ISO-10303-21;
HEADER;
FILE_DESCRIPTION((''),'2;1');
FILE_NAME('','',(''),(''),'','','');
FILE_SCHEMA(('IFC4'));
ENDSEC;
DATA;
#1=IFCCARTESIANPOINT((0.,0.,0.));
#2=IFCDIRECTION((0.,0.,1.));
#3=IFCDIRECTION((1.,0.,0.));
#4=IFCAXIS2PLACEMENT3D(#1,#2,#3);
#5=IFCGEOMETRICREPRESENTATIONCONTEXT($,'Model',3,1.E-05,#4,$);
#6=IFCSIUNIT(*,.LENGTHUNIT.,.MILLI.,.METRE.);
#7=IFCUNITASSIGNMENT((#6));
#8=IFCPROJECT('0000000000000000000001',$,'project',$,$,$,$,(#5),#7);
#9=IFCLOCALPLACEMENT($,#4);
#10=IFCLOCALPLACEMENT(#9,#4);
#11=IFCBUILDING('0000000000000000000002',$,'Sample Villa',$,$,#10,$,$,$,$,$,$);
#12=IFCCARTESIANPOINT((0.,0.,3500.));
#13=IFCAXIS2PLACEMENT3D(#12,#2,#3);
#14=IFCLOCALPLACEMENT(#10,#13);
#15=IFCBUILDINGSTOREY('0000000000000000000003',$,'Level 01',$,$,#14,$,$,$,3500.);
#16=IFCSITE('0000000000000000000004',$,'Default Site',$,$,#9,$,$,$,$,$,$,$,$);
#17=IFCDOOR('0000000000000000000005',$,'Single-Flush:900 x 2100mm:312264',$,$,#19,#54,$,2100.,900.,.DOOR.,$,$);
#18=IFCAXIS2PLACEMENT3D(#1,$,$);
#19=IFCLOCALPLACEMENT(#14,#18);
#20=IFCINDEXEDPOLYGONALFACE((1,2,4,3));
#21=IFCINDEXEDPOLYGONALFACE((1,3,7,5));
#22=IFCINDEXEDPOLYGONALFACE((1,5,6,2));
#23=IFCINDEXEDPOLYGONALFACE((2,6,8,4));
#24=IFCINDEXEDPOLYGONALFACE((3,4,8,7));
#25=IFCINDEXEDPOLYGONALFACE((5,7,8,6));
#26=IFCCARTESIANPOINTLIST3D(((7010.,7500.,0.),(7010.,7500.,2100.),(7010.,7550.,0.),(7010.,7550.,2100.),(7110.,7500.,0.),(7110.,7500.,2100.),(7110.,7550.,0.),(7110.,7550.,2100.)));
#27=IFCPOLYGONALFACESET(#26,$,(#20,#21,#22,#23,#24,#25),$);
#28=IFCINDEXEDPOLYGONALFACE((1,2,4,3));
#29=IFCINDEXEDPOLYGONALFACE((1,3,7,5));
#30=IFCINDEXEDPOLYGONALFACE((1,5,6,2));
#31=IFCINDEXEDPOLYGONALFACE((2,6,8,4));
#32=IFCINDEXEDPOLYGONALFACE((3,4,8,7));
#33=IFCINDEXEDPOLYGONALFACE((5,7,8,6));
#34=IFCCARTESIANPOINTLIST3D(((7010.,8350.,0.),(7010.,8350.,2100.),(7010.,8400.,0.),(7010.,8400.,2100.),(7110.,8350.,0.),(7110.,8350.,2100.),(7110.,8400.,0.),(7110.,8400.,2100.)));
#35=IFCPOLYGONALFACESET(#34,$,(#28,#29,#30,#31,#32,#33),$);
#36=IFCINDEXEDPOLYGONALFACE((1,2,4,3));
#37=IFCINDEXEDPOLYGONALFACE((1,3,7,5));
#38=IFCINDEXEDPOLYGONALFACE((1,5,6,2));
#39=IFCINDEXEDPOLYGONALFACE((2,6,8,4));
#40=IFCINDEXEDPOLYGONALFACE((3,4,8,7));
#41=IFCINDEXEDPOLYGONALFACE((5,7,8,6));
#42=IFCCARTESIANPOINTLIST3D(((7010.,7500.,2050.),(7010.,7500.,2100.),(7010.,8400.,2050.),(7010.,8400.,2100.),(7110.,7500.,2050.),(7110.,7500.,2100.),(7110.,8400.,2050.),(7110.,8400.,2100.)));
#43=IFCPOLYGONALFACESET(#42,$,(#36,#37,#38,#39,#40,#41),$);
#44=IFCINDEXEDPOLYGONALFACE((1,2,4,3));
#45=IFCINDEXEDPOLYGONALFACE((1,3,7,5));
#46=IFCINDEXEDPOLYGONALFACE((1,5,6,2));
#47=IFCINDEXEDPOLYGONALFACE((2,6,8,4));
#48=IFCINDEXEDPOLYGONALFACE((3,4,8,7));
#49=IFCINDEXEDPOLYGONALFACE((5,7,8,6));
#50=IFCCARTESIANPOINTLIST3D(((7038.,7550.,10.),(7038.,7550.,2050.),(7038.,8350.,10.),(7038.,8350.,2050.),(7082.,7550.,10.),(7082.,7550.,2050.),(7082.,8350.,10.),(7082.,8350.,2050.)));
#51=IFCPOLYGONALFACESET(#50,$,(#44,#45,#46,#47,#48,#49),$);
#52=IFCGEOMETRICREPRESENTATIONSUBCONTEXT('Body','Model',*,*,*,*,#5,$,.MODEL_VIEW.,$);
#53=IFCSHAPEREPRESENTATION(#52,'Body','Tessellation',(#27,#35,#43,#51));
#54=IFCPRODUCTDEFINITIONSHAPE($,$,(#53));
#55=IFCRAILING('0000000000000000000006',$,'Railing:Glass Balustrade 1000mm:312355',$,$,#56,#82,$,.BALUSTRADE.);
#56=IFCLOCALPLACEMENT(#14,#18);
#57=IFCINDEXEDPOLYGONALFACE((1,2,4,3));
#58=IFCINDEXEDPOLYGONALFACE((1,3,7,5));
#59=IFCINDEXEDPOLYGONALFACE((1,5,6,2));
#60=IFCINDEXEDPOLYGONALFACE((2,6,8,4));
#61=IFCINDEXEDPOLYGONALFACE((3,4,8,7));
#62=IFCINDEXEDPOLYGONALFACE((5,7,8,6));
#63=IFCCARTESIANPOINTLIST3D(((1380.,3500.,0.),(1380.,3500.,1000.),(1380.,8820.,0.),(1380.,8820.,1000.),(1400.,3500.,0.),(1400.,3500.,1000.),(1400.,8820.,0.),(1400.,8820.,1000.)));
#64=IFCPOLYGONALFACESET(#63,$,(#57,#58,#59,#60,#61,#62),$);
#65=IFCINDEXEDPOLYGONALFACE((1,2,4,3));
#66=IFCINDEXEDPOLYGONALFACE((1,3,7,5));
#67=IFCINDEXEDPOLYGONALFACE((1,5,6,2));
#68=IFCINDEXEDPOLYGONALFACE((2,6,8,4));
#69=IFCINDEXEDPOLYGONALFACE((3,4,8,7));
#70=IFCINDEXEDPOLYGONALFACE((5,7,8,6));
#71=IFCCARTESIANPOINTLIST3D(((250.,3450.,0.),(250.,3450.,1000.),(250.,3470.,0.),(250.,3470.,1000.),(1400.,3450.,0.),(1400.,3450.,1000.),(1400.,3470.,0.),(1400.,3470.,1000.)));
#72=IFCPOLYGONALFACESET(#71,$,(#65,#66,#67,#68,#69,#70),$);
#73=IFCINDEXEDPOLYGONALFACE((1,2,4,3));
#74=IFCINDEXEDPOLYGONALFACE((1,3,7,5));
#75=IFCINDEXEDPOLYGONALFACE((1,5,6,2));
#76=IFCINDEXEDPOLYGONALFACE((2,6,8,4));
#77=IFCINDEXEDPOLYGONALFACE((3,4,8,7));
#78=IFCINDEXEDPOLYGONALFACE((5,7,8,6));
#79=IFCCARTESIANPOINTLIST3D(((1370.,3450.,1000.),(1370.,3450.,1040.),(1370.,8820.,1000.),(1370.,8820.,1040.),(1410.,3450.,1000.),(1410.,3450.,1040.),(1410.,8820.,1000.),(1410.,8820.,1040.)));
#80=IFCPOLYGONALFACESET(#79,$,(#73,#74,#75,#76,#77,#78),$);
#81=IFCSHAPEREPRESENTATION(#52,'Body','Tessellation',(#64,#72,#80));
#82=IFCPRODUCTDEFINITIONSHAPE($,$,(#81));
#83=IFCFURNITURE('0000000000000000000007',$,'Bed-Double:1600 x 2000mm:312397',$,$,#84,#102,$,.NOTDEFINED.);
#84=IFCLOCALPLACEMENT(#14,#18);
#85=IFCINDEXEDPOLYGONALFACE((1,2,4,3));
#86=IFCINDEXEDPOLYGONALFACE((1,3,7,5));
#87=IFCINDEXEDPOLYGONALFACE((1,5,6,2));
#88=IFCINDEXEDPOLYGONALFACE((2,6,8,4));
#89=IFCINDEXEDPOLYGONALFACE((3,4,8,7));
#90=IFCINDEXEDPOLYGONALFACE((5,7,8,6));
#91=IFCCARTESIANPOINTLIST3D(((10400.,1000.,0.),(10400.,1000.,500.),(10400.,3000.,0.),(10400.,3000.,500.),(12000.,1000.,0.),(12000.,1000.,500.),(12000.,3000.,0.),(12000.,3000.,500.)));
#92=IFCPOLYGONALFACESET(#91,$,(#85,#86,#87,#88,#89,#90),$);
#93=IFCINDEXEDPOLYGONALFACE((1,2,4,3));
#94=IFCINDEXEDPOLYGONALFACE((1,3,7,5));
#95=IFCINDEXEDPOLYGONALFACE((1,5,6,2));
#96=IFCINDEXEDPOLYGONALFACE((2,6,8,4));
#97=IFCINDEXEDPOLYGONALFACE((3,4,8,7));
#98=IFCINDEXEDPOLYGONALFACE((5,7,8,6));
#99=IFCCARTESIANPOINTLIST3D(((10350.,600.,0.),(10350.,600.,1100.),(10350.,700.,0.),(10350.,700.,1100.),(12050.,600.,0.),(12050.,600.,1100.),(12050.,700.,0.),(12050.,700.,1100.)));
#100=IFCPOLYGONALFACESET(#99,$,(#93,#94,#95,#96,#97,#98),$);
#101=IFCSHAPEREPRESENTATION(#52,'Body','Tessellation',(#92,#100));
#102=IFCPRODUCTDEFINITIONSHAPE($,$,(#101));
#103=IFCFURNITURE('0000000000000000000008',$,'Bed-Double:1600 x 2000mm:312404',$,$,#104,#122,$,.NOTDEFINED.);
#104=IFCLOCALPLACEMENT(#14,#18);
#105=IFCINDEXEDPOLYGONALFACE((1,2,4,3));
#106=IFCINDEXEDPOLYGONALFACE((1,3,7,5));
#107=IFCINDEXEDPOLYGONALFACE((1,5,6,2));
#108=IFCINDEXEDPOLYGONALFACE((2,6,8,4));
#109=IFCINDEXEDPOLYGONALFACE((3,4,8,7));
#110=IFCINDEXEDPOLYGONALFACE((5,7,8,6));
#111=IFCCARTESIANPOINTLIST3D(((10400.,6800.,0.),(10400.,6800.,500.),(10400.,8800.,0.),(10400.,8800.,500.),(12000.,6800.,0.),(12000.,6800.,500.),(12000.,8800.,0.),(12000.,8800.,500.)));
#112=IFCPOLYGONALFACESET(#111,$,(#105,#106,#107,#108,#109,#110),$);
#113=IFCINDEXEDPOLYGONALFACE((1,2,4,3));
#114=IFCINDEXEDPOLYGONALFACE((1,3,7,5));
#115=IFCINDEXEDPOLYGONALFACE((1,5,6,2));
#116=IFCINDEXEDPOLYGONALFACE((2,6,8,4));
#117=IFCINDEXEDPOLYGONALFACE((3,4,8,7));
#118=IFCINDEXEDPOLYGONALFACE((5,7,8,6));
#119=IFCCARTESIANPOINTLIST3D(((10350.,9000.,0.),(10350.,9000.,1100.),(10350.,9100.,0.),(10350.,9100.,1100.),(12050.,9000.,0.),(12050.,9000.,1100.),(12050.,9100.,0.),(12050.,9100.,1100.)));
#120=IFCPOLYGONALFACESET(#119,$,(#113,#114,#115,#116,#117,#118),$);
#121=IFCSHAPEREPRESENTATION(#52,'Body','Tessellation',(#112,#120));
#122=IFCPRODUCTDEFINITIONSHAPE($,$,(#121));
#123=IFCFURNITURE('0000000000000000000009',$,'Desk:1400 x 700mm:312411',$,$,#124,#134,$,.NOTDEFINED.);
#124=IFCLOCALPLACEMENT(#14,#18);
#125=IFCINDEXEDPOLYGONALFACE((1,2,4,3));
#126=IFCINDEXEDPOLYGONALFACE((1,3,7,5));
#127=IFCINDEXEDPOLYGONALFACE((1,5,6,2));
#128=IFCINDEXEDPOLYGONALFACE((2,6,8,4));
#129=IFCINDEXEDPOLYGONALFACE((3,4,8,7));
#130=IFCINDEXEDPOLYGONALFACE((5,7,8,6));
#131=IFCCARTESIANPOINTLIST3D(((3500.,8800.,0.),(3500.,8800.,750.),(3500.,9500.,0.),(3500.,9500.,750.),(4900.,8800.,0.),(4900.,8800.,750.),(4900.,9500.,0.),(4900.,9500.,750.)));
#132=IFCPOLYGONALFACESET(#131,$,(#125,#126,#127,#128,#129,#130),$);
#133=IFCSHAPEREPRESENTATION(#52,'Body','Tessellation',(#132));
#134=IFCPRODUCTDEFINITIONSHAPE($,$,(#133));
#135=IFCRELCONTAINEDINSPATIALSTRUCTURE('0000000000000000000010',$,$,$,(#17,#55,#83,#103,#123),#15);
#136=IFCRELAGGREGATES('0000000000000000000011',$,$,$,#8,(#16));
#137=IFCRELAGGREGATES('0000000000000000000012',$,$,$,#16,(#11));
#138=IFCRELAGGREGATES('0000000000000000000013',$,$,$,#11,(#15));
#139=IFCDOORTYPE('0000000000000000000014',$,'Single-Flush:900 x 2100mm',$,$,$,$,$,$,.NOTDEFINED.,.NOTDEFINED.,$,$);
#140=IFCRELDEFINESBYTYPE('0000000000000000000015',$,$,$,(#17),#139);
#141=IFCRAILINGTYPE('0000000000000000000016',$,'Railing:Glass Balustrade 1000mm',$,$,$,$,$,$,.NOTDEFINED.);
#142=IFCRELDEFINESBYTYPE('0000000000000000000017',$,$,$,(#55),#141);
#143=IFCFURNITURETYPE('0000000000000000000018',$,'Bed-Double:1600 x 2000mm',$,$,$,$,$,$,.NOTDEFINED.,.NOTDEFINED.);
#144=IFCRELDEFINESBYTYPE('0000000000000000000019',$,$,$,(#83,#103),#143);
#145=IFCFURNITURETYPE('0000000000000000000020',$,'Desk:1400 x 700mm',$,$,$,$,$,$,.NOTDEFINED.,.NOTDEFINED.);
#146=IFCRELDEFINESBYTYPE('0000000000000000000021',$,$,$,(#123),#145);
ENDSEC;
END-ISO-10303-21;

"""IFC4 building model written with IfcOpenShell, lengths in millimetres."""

from ifc_helpers import new_model, si_unit, frame, frame_2d, origin_with_axes, place, context, subcontext, project, spatial, rectangle, extrude, type_object, element, save


model = new_model("IFC4")

# Units and contexts
model_context = context("Model", 3, precision=1e-05, world=origin_with_axes())
body_context = subcontext(model_context, "Body", "Model", "MODEL_VIEW")
ifc_project = project(units=[si_unit("LENGTHUNIT", "METRE", prefix="MILLI")], contexts=[model_context])

# Site, building, storey
site_placement = place(None, origin_with_axes())
site = spatial("IfcSite", under=ifc_project, at=site_placement, Name="Default Site")
building_placement = place(site_placement, origin_with_axes())
building = spatial("IfcBuilding", under=site, at=building_placement, Name="Sample Villa")
storey_placement = place(building_placement, frame((0.0, 0.0, 3500.0), z_axis=(0.0, 0.0, 1.0), x_axis=(1.0, 0.0, 0.0)))
storey = spatial("IfcBuildingStorey", under=building, at=storey_placement, Name="Level 01", Elevation=3500.0)

# Door
door_type = type_object("IfcDoorType", Name="Single-Flush:900 x 2100mm", OperationType="NOTDEFINED", PredefinedType="NOTDEFINED")
door_1_placement = place(storey_placement, frame((0.0, 0.0, -3500.0), z_axis=(0.0, 0.0, 1.0), x_axis=(1.0, 0.0, 0.0)))
element("IfcDoor", 1, at=door_1_placement, inside=storey, type_object=door_type, Name="Single-Flush:900 x 2100mm:312264", OverallHeight=2100.0, OverallWidth=900.0, PredefinedType="DOOR", context=body_context, shape_type="SweptSolid", body=[
    extrude(rectangle(XDim=100.0, YDim=50.0, at=frame_2d((50.0, 25.0))), frame((7010.0, 7500.0, 3500.0)), (0.0, 0.0, 1.0), 2100.0),
    extrude(rectangle(XDim=100.0, YDim=50.0, at=frame_2d((50.0, 25.0))), frame((7010.0, 8350.0, 3500.0)), (0.0, 0.0, 1.0), 2100.0),
    extrude(rectangle(XDim=100.0, YDim=900.0, at=frame_2d((50.0, 450.0))), frame((7010.0, 7500.0, 5550.0)), (0.0, 0.0, 1.0), 50.0),
    extrude(rectangle(XDim=44.0, YDim=800.0, at=frame_2d((22.0, 400.0))), frame((7038.0, 7550.0, 3510.0)), (0.0, 0.0, 1.0), 2040.0),
])

# Railing
railing_type = type_object("IfcRailingType", Name="Railing:Glass Balustrade 1000mm", PredefinedType="NOTDEFINED")
railing_placement = place(storey_placement, frame((0.0, 0.0, -3500.0), z_axis=(0.0, 0.0, 1.0), x_axis=(1.0, 0.0, 0.0)))
element("IfcRailing", 2, at=railing_placement, inside=storey, type_object=railing_type, Name="Railing:Glass Balustrade 1000mm:312355", PredefinedType="BALUSTRADE", context=body_context, shape_type="SweptSolid", body=[
    extrude(rectangle(XDim=20.0, YDim=5320.0, at=frame_2d((10.0, 2660.0))), frame((1380.0, 3500.0, 3500.0)), (0.0, 0.0, 1.0), 1000.0),
    extrude(rectangle(XDim=1150.0, YDim=20.0, at=frame_2d((575.0, 10.0))), frame((250.0, 3450.0, 3500.0)), (0.0, 0.0, 1.0), 1000.0),
    extrude(rectangle(XDim=40.0, YDim=5370.0, at=frame_2d((20.0, 2685.0))), frame((1370.0, 3450.0, 4500.0)), (0.0, 0.0, 1.0), 40.0),
])

# Furniture
furniture_type_1 = type_object("IfcFurnitureType", Name="Bed-Double:1600 x 2000mm", AssemblyPlace="NOTDEFINED", PredefinedType="NOTDEFINED")
furniture_1_placement = place(storey_placement, frame((0.0, 0.0, -3500.0), z_axis=(0.0, 0.0, 1.0), x_axis=(1.0, 0.0, 0.0)))
element("IfcFurniture", 3, at=furniture_1_placement, inside=storey, type_object=furniture_type_1, Name="Bed-Double:1600 x 2000mm:312397", PredefinedType="NOTDEFINED", context=body_context, shape_type="SweptSolid", body=[
    extrude(rectangle(XDim=1600.0, YDim=2000.0, at=frame_2d((800.0, 1000.0))), frame((10400.0, 1000.0, 3500.0)), (0.0, 0.0, 1.0), 500.0),
    extrude(rectangle(XDim=1700.0, YDim=100.0, at=frame_2d((850.0, 50.0))), frame((10350.0, 600.0, 3500.0)), (0.0, 0.0, 1.0), 1100.0),
])
furniture_2_placement = place(storey_placement, frame((0.0, 0.0, -3500.0), z_axis=(0.0, 0.0, 1.0), x_axis=(1.0, 0.0, 0.0)))
element("IfcFurniture", 4, at=furniture_2_placement, inside=storey, type_object=furniture_type_1, Name="Bed-Double:1600 x 2000mm:312404", PredefinedType="NOTDEFINED", context=body_context, shape_type="SweptSolid", body=[
    extrude(rectangle(XDim=1600.0, YDim=2000.0, at=frame_2d((800.0, 1000.0))), frame((10400.0, 6800.0, 3500.0)), (0.0, 0.0, 1.0), 500.0),
    extrude(rectangle(XDim=1700.0, YDim=100.0, at=frame_2d((850.0, 50.0))), frame((10350.0, 9000.0, 3500.0)), (0.0, 0.0, 1.0), 1100.0),
])
furniture_type_2 = type_object("IfcFurnitureType", Name="Desk:1400 x 700mm", AssemblyPlace="NOTDEFINED", PredefinedType="NOTDEFINED")
furniture_3_placement = place(storey_placement, frame((0.0, 0.0, -3500.0), z_axis=(0.0, 0.0, 1.0), x_axis=(1.0, 0.0, 0.0)))
element("IfcFurniture", 5, at=furniture_3_placement, inside=storey, type_object=furniture_type_2, Name="Desk:1400 x 700mm:312411", PredefinedType="NOTDEFINED", context=body_context, shape_type="SweptSolid", body=[
    extrude(rectangle(XDim=1400.0, YDim=700.0, at=frame_2d((700.0, 350.0))), frame((3500.0, 8800.0, 3500.0)), (0.0, 0.0, 1.0), 750.0),
])

save(model, "model.ifc")
